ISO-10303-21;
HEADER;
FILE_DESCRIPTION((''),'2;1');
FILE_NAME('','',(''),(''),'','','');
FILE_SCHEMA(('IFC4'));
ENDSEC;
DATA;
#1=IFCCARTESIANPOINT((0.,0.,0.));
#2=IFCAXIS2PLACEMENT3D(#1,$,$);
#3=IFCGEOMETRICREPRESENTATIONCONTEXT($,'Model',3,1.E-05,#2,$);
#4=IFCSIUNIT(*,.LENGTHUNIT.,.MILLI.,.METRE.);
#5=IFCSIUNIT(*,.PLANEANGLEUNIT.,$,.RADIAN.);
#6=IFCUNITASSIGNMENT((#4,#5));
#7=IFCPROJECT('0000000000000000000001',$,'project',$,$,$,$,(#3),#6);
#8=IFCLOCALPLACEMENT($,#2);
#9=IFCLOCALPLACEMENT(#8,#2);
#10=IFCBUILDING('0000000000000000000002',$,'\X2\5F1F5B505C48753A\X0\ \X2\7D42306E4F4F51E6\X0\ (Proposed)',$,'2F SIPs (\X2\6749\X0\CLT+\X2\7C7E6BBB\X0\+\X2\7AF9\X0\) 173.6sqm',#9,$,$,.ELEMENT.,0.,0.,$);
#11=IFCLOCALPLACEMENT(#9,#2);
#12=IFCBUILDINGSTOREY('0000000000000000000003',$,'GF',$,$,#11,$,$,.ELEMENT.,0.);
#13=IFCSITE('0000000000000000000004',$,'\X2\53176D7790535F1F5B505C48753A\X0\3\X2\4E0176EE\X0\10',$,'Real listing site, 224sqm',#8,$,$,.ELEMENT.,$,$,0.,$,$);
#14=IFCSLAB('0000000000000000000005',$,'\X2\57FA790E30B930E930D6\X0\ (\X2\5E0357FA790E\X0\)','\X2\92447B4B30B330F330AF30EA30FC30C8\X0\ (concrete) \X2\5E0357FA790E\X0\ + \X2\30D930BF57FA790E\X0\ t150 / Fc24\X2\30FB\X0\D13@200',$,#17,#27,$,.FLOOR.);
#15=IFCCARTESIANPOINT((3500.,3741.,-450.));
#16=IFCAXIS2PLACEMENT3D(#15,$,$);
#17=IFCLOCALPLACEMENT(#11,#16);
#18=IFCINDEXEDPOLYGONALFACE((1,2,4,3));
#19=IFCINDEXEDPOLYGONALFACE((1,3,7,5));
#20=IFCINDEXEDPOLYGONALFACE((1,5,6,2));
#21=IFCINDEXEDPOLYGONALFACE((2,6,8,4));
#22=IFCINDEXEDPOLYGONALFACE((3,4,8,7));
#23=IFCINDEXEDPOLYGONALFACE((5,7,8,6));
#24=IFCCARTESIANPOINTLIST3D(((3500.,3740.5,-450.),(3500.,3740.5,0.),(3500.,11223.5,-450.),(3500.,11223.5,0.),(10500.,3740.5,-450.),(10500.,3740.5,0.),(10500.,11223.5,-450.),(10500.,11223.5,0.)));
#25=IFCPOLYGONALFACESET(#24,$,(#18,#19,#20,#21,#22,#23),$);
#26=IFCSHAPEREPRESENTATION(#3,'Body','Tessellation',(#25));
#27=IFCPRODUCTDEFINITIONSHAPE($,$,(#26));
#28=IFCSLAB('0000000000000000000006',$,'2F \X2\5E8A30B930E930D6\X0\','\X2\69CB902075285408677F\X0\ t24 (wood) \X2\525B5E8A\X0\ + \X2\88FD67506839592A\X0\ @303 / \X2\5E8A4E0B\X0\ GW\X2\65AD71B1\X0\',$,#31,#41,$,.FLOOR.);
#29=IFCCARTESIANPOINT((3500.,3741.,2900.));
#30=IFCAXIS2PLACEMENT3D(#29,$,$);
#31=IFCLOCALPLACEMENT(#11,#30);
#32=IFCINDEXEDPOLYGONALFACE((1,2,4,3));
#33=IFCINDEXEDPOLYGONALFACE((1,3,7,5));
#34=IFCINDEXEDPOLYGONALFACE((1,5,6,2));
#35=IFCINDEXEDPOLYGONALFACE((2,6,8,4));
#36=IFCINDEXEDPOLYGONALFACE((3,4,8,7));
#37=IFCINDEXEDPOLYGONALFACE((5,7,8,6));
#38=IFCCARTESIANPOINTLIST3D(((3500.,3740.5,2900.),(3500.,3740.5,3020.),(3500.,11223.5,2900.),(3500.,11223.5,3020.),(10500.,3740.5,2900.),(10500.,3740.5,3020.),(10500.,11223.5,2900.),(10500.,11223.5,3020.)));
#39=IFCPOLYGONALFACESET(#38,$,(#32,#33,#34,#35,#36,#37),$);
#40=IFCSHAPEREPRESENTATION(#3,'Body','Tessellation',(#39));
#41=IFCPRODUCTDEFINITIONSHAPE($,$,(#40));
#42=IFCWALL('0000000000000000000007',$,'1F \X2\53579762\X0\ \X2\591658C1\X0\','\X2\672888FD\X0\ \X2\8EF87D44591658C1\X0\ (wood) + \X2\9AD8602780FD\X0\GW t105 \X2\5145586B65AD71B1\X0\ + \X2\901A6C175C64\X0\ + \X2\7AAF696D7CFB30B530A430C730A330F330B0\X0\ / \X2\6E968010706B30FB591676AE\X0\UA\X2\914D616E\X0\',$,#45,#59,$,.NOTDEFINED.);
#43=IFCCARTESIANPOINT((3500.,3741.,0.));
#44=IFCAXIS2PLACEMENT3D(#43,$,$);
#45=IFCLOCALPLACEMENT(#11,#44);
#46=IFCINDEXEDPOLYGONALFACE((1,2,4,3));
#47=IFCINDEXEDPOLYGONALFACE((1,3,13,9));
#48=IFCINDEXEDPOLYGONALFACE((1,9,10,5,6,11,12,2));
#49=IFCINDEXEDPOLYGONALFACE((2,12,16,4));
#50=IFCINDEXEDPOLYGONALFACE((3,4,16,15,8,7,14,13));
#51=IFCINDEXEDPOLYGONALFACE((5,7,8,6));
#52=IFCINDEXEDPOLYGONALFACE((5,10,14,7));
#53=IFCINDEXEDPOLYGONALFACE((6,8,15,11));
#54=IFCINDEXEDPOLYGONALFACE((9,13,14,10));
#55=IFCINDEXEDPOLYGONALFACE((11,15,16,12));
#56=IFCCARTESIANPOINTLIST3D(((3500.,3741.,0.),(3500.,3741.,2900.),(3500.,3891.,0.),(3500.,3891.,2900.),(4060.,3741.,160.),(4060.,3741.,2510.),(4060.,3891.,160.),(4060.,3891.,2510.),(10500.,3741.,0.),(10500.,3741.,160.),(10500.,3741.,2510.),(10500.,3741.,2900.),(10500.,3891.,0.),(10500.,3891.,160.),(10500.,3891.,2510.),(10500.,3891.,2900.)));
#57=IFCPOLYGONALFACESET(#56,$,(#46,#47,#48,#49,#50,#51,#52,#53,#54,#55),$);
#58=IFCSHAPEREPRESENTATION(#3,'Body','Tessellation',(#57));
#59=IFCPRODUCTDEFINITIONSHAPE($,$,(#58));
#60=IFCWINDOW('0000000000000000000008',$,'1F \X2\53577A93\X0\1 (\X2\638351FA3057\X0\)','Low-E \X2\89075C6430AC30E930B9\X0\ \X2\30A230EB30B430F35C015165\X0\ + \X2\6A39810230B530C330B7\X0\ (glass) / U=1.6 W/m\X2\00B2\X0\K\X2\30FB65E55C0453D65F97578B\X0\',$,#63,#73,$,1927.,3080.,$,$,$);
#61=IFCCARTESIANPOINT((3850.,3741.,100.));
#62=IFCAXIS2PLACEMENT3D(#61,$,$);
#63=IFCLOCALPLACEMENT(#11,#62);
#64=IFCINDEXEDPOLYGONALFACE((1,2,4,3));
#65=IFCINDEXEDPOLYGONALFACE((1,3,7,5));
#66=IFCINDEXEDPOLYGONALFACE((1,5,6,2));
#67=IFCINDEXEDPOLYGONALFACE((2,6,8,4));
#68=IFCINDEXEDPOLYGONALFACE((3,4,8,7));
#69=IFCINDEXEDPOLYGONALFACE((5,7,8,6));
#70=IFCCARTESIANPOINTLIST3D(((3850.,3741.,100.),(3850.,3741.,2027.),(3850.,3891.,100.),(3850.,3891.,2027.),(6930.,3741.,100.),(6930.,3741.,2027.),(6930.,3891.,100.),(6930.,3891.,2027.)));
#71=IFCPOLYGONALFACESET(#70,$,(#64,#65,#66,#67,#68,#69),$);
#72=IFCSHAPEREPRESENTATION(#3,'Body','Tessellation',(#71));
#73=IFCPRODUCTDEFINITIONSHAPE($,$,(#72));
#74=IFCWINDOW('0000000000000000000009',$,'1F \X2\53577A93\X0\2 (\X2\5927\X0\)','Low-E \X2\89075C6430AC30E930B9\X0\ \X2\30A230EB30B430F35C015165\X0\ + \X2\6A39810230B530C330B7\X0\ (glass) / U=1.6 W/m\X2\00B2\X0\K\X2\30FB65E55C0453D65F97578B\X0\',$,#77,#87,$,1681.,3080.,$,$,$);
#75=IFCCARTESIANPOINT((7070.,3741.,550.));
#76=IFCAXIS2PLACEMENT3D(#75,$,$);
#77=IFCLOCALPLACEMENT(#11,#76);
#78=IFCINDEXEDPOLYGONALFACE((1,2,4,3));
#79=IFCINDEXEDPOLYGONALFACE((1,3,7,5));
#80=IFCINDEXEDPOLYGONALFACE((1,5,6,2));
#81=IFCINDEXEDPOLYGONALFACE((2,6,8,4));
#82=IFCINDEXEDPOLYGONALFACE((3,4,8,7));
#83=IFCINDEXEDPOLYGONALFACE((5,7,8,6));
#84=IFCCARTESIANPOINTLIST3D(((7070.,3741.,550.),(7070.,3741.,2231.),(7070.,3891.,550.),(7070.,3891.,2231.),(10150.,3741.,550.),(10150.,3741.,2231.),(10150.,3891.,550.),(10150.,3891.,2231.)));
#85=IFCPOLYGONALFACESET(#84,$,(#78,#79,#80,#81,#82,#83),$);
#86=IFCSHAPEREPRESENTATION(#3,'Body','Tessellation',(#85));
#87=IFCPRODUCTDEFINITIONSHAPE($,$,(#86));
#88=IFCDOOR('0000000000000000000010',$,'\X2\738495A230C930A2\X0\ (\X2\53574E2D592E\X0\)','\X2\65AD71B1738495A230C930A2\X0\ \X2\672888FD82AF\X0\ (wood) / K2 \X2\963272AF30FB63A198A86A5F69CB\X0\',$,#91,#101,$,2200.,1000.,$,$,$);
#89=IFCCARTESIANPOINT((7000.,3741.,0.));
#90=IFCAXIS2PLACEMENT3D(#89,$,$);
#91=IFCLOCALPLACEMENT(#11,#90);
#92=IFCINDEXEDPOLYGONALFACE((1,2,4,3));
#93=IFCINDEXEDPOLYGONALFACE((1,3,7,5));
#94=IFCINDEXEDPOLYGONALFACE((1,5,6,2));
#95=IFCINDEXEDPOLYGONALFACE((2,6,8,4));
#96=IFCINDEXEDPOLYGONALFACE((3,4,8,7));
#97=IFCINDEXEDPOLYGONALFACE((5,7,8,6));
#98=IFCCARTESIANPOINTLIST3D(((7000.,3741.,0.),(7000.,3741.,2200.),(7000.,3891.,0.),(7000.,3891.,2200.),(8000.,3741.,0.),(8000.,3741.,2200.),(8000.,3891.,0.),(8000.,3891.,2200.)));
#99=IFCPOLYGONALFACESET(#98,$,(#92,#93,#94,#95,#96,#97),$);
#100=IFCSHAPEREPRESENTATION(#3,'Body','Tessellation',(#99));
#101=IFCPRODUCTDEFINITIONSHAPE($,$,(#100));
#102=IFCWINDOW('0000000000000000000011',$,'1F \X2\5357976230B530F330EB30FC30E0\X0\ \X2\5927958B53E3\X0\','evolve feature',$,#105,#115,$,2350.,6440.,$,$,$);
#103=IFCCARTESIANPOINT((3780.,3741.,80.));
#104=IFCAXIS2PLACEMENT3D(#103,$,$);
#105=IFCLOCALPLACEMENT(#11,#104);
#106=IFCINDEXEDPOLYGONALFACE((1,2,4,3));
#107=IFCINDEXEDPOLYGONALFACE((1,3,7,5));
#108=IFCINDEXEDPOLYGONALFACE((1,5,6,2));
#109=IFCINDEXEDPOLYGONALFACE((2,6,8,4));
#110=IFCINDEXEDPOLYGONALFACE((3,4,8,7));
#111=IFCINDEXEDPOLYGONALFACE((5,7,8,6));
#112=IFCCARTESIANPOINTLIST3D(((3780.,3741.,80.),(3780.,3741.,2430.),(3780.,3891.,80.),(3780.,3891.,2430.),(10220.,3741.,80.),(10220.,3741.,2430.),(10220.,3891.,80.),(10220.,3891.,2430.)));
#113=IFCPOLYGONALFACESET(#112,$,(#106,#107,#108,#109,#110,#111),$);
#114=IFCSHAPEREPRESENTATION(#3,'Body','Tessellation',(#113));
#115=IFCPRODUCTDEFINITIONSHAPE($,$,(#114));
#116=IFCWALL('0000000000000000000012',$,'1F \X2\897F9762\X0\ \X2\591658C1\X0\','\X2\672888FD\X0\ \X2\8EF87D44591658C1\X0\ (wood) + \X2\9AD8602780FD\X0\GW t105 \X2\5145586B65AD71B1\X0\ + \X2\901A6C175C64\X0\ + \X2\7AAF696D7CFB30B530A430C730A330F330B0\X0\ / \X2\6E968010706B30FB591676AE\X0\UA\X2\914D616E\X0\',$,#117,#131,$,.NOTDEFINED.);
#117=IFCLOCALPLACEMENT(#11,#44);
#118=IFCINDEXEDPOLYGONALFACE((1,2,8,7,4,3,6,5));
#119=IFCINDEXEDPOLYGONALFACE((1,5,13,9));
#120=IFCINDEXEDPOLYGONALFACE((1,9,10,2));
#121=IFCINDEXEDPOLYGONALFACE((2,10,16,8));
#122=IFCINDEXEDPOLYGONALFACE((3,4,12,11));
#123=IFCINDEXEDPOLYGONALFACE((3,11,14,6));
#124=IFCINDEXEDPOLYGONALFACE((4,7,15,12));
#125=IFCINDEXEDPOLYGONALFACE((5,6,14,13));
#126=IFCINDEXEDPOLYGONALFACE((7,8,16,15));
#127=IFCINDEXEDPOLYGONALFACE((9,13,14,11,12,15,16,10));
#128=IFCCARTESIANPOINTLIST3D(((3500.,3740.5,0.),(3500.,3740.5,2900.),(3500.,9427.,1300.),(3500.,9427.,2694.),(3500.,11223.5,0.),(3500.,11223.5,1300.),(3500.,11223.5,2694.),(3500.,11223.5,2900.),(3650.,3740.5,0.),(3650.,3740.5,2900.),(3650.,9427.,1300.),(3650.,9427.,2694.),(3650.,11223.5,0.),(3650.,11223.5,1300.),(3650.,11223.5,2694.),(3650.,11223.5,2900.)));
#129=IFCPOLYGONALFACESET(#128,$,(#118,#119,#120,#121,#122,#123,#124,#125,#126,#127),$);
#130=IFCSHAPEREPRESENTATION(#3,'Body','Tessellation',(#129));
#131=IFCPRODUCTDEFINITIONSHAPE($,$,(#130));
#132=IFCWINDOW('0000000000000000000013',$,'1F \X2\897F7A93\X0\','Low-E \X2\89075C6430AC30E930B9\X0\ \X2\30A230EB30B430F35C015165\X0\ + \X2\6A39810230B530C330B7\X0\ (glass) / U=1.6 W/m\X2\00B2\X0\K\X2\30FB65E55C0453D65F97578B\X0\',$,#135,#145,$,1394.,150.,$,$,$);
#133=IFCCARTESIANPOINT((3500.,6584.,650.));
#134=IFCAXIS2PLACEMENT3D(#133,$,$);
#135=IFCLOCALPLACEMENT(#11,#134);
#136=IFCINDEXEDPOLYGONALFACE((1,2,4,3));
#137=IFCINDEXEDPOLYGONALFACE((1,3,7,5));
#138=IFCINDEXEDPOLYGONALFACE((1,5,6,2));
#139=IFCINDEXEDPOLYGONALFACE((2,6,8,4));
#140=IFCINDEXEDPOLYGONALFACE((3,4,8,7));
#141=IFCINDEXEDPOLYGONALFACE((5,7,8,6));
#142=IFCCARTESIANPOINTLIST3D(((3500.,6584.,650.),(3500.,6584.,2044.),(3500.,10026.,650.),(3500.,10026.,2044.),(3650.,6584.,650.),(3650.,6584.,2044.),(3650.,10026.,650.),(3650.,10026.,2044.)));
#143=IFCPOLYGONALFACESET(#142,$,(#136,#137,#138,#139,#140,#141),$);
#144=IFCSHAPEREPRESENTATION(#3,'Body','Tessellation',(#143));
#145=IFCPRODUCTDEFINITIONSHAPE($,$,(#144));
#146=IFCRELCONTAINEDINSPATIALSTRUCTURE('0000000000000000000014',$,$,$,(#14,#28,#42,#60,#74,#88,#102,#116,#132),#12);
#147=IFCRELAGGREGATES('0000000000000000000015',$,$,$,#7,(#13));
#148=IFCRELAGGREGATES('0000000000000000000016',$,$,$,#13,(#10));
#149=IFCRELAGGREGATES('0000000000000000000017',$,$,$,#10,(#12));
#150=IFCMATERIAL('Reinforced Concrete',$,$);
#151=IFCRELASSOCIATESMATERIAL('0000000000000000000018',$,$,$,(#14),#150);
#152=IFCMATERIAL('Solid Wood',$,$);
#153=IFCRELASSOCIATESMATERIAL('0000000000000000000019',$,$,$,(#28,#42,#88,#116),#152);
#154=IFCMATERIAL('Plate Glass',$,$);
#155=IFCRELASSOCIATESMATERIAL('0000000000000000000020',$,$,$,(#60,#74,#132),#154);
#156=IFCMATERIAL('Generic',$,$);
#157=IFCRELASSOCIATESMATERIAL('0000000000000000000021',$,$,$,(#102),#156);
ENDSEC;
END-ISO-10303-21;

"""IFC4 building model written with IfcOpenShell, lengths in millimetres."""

from ifc_helpers import new_model, si_unit, frame, frame_2d, origin, place, context, project, spatial, rectangle, extrude, material, element, fill, save


model = new_model("IFC4")

# Units and contexts
model_context = context("Model", 3, precision=1e-05, world=origin())
ifc_project = project(units=[si_unit("LENGTHUNIT", "METRE", prefix="MILLI"), si_unit("PLANEANGLEUNIT", "RADIAN")], contexts=[model_context])

# Site, building, storey
site_placement = place(None, origin())
site = spatial("IfcSite", under=ifc_project, at=site_placement, Name="北海道弟子屈町3丁目10", ObjectType="Real listing site, 224sqm", CompositionType="ELEMENT", RefElevation=0.0)
building_placement = place(site_placement, origin())
building = spatial("IfcBuilding", under=site, at=building_placement, Name="弟子屈町 終の住処 (Proposed)", ObjectType="2F SIPs (杉CLT+籾殻+竹) 173.6sqm", CompositionType="ELEMENT", ElevationOfRefHeight=0.0, ElevationOfTerrain=0.0)
storey_placement = place(building_placement, origin())
storey = spatial("IfcBuildingStorey", under=building, at=storey_placement, Name="GF", CompositionType="ELEMENT", Elevation=0.0)

# Slabs
ifc_material_1 = material(Name="Reinforced Concrete")
slab_1_placement = place(storey_placement, frame((3500.0, 3741.0, -450.0)))
element("IfcSlab", 1, at=slab_1_placement, inside=storey, material=ifc_material_1, Name="基礎スラブ (布基礎)", Description="鉄筋コンクリート (concrete) 布基礎 + ベタ基礎 t150 / Fc24・D13@200", PredefinedType="FLOOR", context=model_context, shape_type="SweptSolid", body=[
    extrude(rectangle(XDim=7000.0, YDim=7483.0, at=frame_2d((3500.0, 3741.0))), frame((3500.0, 3741.0, -450.0)), (0.0, 0.0, 1.0), 450.0),
])
ifc_material_2 = material(Name="Solid Wood")
slab_2_placement = place(storey_placement, frame((3500.0, 3741.0, 2900.0)))
element("IfcSlab", 2, at=slab_2_placement, inside=storey, material=ifc_material_2, Name="2F 床スラブ", Description="構造用合板 t24 (wood) 剛床 + 製材根太 @303 / 床下 GW断熱", PredefinedType="FLOOR", context=model_context, shape_type="SweptSolid", body=[
    extrude(rectangle(XDim=7000.0, YDim=7483.0, at=frame_2d((3500.0, 3741.0))), frame((3500.0, 3741.0, 2900.0)), (0.0, 0.0, 1.0), 120.0),
])
ifc_material_3 = material(Name="Generic")

# Wall, openings, windows, door
wall_1_placement = place(storey_placement, frame((3500.0, 3741.0, 0.0)))
wall_1 = element("IfcWall", 3, at=wall_1_placement, inside=storey, material=ifc_material_2, Name="1F 南面 外壁", Description="木製 軸組外壁 (wood) + 高性能GW t105 充填断熱 + 通気層 + 窯業系サイディング / 準耐火・外皮UA配慮", PredefinedType="NOTDEFINED", context=model_context, shape_type="SweptSolid", body=[
    extrude(rectangle(XDim=7000.0, YDim=150.0, at=frame_2d((3500.0, 75.0))), frame((3500.0, 3741.0, 0.0)), (0.0, 0.0, 1.0), 2900.0),
])
opening_1_placement = place(storey_placement, frame((3850.0, 3741.0, 100.0)))
opening_1 = element("IfcOpeningElement", 4, at=opening_1_placement, cuts=wall_1, PredefinedType="NOTDEFINED", context=model_context, shape_type="SweptSolid", body=[
    extrude(rectangle(XDim=3080.0, YDim=150.0, at=frame_2d((1540.0, 75.0))), frame((3850.0, 3741.0, 100.0)), (0.0, 0.0, 1.0), 1927.0),
])
opening_2_placement = place(storey_placement, frame((7070.0, 3741.0, 550.0)))
opening_2 = element("IfcOpeningElement", 5, at=opening_2_placement, cuts=wall_1, PredefinedType="NOTDEFINED", context=model_context, shape_type="SweptSolid", body=[
    extrude(rectangle(XDim=3080.0, YDim=150.0, at=frame_2d((1540.0, 75.0))), frame((7070.0, 3741.0, 550.0)), (0.0, 0.0, 1.0), 1681.0),
])
opening_3_placement = place(storey_placement, frame((7000.0, 3741.0, 0.0)))
opening_3 = element("IfcOpeningElement", 6, at=opening_3_placement, cuts=wall_1, PredefinedType="NOTDEFINED", context=model_context, shape_type="SweptSolid", body=[
    extrude(rectangle(XDim=1000.0, YDim=150.0, at=frame_2d((500.0, 75.0))), frame((7000.0, 3741.0, 0.0)), (0.0, 0.0, 1.0), 2200.0),
])
opening_4_placement = place(storey_placement, frame((3780.0, 3741.0, 80.0)))
opening_4 = element("IfcOpeningElement", 7, at=opening_4_placement, cuts=wall_1, PredefinedType="NOTDEFINED", context=model_context, shape_type="SweptSolid", body=[
    extrude(rectangle(XDim=6440.0, YDim=150.0, at=frame_2d((3220.0, 75.0))), frame((3780.0, 3741.0, 80.0)), (0.0, 0.0, 1.0), 2350.0),
])
ifc_material_4 = material(Name="Plate Glass")
window_1_placement = place(storey_placement, frame((3850.0, 3741.0, 100.0)))
window_1 = element("IfcWindow", 8, at=window_1_placement, inside=storey, material=ifc_material_4, Name="1F 南窓1 (掃出し)", Description="Low-E 複層ガラス アルゴン封入 + 樹脂サッシ (glass) / U=1.6 W/m²K・日射取得型", OverallHeight=1927.0, OverallWidth=3080.0, context=model_context, shape_type="SweptSolid", body=[
    extrude(rectangle(XDim=3080.0, YDim=150.0, at=frame_2d((1540.0, 75.0))), frame((3850.0, 3741.0, 100.0)), (0.0, 0.0, 1.0), 1927.0),
])
fill(opening_1, window_1)
window_2_placement = place(storey_placement, frame((7070.0, 3741.0, 550.0)))
window_2 = element("IfcWindow", 9, at=window_2_placement, inside=storey, material=ifc_material_4, Name="1F 南窓2 (大)", Description="Low-E 複層ガラス アルゴン封入 + 樹脂サッシ (glass) / U=1.6 W/m²K・日射取得型", OverallHeight=1681.0, OverallWidth=3080.0, context=model_context, shape_type="SweptSolid", body=[
    extrude(rectangle(XDim=3080.0, YDim=150.0, at=frame_2d((1540.0, 75.0))), frame((7070.0, 3741.0, 550.0)), (0.0, 0.0, 1.0), 1681.0),
])
fill(opening_2, window_2)
door_placement = place(storey_placement, frame((7000.0, 3741.0, 0.0)))
door = element("IfcDoor", 10, at=door_placement, inside=storey, material=ifc_material_2, Name="玄関ドア (南中央)", Description="断熱玄関ドア 木製芯 (wood) / K2 防犯・採風機構", OverallHeight=2200.0, OverallWidth=1000.0, context=model_context, shape_type="SweptSolid", body=[
    extrude(rectangle(XDim=1000.0, YDim=150.0, at=frame_2d((500.0, 75.0))), frame((7000.0, 3741.0, 0.0)), (0.0, 0.0, 1.0), 2200.0),
])
fill(opening_3, door)
window_3_placement = place(storey_placement, frame((3780.0, 3741.0, 80.0)))
window_3 = element("IfcWindow", 11, at=window_3_placement, inside=storey, material=ifc_material_3, Name="1F 南面サンルーム 大開口", Description="evolve feature", OverallHeight=2350.0, OverallWidth=6440.0, context=model_context, shape_type="SweptSolid", body=[
    extrude(rectangle(XDim=6440.0, YDim=150.0, at=frame_2d((3220.0, 75.0))), frame((3780.0, 3741.0, 80.0)), (0.0, 0.0, 1.0), 2350.0),
])
fill(opening_4, window_3)

# Wall, opening, window
wall_2_placement = place(storey_placement, frame((3500.0, 3741.0, 0.0)))
wall_2 = element("IfcWall", 12, at=wall_2_placement, inside=storey, material=ifc_material_2, Name="1F 西面 外壁", Description="木製 軸組外壁 (wood) + 高性能GW t105 充填断熱 + 通気層 + 窯業系サイディング / 準耐火・外皮UA配慮", PredefinedType="NOTDEFINED", context=model_context, shape_type="SweptSolid", body=[
    extrude(rectangle(XDim=150.0, YDim=7483.0, at=frame_2d((75.0, 3741.0))), frame((3500.0, 3741.0, 0.0)), (0.0, 0.0, 1.0), 2900.0),
])
opening_5_placement = place(storey_placement, frame((3500.0, 6584.0, 650.0)))
opening_5 = element("IfcOpeningElement", 13, at=opening_5_placement, cuts=wall_2, PredefinedType="NOTDEFINED", context=model_context, shape_type="SweptSolid", body=[
    extrude(rectangle(XDim=150.0, YDim=3442.0, at=frame_2d((75.0, 1721.0))), frame((3500.0, 6584.0, 650.0)), (0.0, 0.0, 1.0), 1394.0),
])
window_4_placement = place(storey_placement, frame((3500.0, 6584.0, 650.0)))
window_4 = element("IfcWindow", 14, at=window_4_placement, inside=storey, material=ifc_material_4, Name="1F 西窓", Description="Low-E 複層ガラス アルゴン封入 + 樹脂サッシ (glass) / U=1.6 W/m²K・日射取得型", OverallHeight=1394.0, OverallWidth=150.0, context=model_context, shape_type="SweptSolid", body=[
    extrude(rectangle(XDim=150.0, YDim=3442.0, at=frame_2d((75.0, 1721.0))), frame((3500.0, 6584.0, 650.0)), (0.0, 0.0, 1.0), 1394.0),
])
fill(opening_5, window_4)

save(model, "model.ifc")
